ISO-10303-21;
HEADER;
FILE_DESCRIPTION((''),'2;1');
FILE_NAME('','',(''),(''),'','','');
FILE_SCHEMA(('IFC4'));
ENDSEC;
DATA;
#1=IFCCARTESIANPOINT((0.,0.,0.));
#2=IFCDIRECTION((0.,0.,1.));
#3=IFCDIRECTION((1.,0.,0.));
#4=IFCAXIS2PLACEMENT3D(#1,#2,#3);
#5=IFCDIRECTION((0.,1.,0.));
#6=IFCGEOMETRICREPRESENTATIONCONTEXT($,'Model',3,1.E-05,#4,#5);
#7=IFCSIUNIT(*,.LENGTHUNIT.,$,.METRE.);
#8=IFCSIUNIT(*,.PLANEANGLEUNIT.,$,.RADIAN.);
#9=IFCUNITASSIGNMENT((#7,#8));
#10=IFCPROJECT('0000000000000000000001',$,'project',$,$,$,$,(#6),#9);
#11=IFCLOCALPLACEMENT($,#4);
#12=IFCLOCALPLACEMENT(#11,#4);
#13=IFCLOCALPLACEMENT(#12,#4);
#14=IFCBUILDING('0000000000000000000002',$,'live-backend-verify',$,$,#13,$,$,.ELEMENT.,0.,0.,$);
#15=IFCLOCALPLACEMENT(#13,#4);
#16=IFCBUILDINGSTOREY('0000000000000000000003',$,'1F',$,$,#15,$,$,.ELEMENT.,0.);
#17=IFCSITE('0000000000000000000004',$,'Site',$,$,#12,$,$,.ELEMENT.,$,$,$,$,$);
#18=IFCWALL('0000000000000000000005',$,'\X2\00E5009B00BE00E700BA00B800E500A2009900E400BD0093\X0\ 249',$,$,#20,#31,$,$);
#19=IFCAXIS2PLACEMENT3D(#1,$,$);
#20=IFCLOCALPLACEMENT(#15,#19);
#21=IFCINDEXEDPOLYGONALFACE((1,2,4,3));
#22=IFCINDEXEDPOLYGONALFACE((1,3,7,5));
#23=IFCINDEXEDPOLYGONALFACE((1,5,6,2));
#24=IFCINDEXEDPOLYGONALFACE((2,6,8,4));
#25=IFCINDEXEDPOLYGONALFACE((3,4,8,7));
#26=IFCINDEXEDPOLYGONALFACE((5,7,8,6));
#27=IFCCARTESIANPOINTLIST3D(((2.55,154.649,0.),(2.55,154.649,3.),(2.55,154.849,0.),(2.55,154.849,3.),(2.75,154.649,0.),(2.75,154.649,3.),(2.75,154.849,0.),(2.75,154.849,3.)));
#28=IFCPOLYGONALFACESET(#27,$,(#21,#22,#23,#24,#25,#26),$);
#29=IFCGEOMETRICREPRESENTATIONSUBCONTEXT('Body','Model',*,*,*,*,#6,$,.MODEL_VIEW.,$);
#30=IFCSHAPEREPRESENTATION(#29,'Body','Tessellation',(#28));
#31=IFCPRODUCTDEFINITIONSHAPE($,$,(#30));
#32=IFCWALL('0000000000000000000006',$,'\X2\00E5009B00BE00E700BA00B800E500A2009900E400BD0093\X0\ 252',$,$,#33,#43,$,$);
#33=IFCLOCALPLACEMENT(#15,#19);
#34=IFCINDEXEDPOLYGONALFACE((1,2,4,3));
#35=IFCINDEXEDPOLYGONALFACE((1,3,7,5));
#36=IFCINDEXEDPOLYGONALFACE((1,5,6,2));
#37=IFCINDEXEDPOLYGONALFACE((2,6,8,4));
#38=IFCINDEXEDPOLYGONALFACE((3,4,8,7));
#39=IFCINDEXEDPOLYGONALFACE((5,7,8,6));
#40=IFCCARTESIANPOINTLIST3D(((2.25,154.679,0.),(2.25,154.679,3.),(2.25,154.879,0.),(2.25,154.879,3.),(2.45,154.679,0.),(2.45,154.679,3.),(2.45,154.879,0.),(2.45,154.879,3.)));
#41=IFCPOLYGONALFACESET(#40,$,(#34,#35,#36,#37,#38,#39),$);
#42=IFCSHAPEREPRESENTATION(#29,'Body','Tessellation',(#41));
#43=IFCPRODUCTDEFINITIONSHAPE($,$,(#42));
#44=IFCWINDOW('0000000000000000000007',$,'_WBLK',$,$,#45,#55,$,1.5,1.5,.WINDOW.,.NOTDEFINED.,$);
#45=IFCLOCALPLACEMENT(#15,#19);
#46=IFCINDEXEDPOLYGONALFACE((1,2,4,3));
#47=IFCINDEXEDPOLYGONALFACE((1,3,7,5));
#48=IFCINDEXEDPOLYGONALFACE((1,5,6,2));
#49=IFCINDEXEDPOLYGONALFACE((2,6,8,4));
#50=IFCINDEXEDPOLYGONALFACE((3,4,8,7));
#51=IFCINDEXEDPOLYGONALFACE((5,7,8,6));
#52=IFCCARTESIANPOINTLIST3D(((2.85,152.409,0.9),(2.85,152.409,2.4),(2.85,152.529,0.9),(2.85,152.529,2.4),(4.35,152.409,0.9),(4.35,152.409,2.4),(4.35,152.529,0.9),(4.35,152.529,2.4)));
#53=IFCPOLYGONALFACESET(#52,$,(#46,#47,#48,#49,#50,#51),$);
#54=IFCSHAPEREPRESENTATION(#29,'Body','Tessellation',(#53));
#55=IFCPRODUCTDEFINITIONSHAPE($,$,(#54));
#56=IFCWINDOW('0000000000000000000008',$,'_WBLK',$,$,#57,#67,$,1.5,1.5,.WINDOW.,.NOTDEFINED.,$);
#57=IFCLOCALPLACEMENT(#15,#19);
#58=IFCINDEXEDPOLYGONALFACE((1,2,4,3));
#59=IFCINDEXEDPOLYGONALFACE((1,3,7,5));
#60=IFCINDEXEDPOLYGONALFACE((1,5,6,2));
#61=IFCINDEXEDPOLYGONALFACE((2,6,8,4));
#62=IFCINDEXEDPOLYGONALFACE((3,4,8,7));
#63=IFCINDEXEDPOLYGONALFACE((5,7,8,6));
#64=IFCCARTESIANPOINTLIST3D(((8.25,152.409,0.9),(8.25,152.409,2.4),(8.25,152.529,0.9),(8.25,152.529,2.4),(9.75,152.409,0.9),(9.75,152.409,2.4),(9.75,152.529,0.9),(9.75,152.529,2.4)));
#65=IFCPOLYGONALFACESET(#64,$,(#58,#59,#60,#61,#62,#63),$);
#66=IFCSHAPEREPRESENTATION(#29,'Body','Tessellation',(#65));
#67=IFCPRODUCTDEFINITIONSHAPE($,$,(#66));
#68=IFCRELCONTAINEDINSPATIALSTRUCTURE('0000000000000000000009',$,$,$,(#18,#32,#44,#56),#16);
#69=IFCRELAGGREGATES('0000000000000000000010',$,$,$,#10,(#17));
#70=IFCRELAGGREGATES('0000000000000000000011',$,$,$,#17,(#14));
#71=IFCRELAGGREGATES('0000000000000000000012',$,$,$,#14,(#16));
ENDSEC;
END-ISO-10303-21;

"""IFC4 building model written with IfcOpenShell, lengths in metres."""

from ifc_helpers import new_model, si_unit, direction, frame, frame_2d, origin_with_axes, place, context, subcontext, project, spatial, rectangle, extrude, element, save


model = new_model("IFC4")

# Units and contexts
model_context = context("Model", 3, precision=1e-05, world=origin_with_axes(), true_north=direction((0.0, 1.0, 0.0)))
body_context = subcontext(model_context, "Body", "Model", "MODEL_VIEW")
ifc_project = project(units=[si_unit("LENGTHUNIT", "METRE"), si_unit("PLANEANGLEUNIT", "RADIAN")], contexts=[model_context])

# Site, building, storey
placement = place(None, origin_with_axes())
site_placement = place(placement, origin_with_axes())
site = spatial("IfcSite", under=ifc_project, at=site_placement, Name="Site", CompositionType="ELEMENT")
building_placement = place(site_placement, origin_with_axes())
building = spatial("IfcBuilding", under=site, at=building_placement, Name="live-backend-verify", CompositionType="ELEMENT", ElevationOfRefHeight=0.0, ElevationOfTerrain=0.0)
storey_placement = place(building_placement, origin_with_axes())
storey = spatial("IfcBuildingStorey", under=building, at=storey_placement, Name="1F", CompositionType="ELEMENT", Elevation=0.0)

# Walls
for number, where, z_axis, x_axis, name in (
    (1, (2.65, 154.749, 0.0), (0.0, 0.0, 1.0), (0.0, 1.0, 0.0), "å\u009b¾çº¸å¢\u0099ä½\u0093 249"),
    (2, (2.35, 154.779, 0.0), (0.0, 0.0, 1.0), (0.0, 1.0, 0.0), "å\u009b¾çº¸å¢\u0099ä½\u0093 252"),
):
    element("IfcWall", number, at=place(storey_placement, frame(where, z_axis=z_axis, x_axis=x_axis)), inside=storey, Name=name, context=body_context, shape_type="SweptSolid", body=[
        extrude(rectangle(XDim=0.2, YDim=0.2, at=frame_2d((0.0, 0.0), x_axis=(1.0, 0.0, 0.0))), frame((0.0, 0.0, 0.0), z_axis=(0.0, 0.0, 1.0)), (0.0, 0.0, 1.0), 3.0),
    ])

# Windows
for number, where, z_axis, x_axis, name in (
    (3, (3.6, 152.469, 0.9), (0.0, 0.0, 1.0), (1.0, 0.0, 0.0), "_WBLK"),
    (4, (9.0, 152.469, 0.9), (0.0, 0.0, 1.0), (1.0, 0.0, 0.0), "_WBLK"),
):
    element("IfcWindow", number, at=place(storey_placement, frame(where, z_axis=z_axis, x_axis=x_axis)), inside=storey, Name=name, OverallHeight=1.5, OverallWidth=1.5, PartitioningType="NOTDEFINED", PredefinedType="WINDOW", context=body_context, shape_type="SweptSolid", body=[
        extrude(rectangle(XDim=1.5, YDim=0.12, at=frame_2d((0.0, 0.0), x_axis=(1.0, 0.0, 0.0))), frame((0.0, 0.0, 0.0), z_axis=(0.0, 0.0, 1.0)), (0.0, 0.0, 1.0), 1.5),
    ])

save(model, "model.ifc")
